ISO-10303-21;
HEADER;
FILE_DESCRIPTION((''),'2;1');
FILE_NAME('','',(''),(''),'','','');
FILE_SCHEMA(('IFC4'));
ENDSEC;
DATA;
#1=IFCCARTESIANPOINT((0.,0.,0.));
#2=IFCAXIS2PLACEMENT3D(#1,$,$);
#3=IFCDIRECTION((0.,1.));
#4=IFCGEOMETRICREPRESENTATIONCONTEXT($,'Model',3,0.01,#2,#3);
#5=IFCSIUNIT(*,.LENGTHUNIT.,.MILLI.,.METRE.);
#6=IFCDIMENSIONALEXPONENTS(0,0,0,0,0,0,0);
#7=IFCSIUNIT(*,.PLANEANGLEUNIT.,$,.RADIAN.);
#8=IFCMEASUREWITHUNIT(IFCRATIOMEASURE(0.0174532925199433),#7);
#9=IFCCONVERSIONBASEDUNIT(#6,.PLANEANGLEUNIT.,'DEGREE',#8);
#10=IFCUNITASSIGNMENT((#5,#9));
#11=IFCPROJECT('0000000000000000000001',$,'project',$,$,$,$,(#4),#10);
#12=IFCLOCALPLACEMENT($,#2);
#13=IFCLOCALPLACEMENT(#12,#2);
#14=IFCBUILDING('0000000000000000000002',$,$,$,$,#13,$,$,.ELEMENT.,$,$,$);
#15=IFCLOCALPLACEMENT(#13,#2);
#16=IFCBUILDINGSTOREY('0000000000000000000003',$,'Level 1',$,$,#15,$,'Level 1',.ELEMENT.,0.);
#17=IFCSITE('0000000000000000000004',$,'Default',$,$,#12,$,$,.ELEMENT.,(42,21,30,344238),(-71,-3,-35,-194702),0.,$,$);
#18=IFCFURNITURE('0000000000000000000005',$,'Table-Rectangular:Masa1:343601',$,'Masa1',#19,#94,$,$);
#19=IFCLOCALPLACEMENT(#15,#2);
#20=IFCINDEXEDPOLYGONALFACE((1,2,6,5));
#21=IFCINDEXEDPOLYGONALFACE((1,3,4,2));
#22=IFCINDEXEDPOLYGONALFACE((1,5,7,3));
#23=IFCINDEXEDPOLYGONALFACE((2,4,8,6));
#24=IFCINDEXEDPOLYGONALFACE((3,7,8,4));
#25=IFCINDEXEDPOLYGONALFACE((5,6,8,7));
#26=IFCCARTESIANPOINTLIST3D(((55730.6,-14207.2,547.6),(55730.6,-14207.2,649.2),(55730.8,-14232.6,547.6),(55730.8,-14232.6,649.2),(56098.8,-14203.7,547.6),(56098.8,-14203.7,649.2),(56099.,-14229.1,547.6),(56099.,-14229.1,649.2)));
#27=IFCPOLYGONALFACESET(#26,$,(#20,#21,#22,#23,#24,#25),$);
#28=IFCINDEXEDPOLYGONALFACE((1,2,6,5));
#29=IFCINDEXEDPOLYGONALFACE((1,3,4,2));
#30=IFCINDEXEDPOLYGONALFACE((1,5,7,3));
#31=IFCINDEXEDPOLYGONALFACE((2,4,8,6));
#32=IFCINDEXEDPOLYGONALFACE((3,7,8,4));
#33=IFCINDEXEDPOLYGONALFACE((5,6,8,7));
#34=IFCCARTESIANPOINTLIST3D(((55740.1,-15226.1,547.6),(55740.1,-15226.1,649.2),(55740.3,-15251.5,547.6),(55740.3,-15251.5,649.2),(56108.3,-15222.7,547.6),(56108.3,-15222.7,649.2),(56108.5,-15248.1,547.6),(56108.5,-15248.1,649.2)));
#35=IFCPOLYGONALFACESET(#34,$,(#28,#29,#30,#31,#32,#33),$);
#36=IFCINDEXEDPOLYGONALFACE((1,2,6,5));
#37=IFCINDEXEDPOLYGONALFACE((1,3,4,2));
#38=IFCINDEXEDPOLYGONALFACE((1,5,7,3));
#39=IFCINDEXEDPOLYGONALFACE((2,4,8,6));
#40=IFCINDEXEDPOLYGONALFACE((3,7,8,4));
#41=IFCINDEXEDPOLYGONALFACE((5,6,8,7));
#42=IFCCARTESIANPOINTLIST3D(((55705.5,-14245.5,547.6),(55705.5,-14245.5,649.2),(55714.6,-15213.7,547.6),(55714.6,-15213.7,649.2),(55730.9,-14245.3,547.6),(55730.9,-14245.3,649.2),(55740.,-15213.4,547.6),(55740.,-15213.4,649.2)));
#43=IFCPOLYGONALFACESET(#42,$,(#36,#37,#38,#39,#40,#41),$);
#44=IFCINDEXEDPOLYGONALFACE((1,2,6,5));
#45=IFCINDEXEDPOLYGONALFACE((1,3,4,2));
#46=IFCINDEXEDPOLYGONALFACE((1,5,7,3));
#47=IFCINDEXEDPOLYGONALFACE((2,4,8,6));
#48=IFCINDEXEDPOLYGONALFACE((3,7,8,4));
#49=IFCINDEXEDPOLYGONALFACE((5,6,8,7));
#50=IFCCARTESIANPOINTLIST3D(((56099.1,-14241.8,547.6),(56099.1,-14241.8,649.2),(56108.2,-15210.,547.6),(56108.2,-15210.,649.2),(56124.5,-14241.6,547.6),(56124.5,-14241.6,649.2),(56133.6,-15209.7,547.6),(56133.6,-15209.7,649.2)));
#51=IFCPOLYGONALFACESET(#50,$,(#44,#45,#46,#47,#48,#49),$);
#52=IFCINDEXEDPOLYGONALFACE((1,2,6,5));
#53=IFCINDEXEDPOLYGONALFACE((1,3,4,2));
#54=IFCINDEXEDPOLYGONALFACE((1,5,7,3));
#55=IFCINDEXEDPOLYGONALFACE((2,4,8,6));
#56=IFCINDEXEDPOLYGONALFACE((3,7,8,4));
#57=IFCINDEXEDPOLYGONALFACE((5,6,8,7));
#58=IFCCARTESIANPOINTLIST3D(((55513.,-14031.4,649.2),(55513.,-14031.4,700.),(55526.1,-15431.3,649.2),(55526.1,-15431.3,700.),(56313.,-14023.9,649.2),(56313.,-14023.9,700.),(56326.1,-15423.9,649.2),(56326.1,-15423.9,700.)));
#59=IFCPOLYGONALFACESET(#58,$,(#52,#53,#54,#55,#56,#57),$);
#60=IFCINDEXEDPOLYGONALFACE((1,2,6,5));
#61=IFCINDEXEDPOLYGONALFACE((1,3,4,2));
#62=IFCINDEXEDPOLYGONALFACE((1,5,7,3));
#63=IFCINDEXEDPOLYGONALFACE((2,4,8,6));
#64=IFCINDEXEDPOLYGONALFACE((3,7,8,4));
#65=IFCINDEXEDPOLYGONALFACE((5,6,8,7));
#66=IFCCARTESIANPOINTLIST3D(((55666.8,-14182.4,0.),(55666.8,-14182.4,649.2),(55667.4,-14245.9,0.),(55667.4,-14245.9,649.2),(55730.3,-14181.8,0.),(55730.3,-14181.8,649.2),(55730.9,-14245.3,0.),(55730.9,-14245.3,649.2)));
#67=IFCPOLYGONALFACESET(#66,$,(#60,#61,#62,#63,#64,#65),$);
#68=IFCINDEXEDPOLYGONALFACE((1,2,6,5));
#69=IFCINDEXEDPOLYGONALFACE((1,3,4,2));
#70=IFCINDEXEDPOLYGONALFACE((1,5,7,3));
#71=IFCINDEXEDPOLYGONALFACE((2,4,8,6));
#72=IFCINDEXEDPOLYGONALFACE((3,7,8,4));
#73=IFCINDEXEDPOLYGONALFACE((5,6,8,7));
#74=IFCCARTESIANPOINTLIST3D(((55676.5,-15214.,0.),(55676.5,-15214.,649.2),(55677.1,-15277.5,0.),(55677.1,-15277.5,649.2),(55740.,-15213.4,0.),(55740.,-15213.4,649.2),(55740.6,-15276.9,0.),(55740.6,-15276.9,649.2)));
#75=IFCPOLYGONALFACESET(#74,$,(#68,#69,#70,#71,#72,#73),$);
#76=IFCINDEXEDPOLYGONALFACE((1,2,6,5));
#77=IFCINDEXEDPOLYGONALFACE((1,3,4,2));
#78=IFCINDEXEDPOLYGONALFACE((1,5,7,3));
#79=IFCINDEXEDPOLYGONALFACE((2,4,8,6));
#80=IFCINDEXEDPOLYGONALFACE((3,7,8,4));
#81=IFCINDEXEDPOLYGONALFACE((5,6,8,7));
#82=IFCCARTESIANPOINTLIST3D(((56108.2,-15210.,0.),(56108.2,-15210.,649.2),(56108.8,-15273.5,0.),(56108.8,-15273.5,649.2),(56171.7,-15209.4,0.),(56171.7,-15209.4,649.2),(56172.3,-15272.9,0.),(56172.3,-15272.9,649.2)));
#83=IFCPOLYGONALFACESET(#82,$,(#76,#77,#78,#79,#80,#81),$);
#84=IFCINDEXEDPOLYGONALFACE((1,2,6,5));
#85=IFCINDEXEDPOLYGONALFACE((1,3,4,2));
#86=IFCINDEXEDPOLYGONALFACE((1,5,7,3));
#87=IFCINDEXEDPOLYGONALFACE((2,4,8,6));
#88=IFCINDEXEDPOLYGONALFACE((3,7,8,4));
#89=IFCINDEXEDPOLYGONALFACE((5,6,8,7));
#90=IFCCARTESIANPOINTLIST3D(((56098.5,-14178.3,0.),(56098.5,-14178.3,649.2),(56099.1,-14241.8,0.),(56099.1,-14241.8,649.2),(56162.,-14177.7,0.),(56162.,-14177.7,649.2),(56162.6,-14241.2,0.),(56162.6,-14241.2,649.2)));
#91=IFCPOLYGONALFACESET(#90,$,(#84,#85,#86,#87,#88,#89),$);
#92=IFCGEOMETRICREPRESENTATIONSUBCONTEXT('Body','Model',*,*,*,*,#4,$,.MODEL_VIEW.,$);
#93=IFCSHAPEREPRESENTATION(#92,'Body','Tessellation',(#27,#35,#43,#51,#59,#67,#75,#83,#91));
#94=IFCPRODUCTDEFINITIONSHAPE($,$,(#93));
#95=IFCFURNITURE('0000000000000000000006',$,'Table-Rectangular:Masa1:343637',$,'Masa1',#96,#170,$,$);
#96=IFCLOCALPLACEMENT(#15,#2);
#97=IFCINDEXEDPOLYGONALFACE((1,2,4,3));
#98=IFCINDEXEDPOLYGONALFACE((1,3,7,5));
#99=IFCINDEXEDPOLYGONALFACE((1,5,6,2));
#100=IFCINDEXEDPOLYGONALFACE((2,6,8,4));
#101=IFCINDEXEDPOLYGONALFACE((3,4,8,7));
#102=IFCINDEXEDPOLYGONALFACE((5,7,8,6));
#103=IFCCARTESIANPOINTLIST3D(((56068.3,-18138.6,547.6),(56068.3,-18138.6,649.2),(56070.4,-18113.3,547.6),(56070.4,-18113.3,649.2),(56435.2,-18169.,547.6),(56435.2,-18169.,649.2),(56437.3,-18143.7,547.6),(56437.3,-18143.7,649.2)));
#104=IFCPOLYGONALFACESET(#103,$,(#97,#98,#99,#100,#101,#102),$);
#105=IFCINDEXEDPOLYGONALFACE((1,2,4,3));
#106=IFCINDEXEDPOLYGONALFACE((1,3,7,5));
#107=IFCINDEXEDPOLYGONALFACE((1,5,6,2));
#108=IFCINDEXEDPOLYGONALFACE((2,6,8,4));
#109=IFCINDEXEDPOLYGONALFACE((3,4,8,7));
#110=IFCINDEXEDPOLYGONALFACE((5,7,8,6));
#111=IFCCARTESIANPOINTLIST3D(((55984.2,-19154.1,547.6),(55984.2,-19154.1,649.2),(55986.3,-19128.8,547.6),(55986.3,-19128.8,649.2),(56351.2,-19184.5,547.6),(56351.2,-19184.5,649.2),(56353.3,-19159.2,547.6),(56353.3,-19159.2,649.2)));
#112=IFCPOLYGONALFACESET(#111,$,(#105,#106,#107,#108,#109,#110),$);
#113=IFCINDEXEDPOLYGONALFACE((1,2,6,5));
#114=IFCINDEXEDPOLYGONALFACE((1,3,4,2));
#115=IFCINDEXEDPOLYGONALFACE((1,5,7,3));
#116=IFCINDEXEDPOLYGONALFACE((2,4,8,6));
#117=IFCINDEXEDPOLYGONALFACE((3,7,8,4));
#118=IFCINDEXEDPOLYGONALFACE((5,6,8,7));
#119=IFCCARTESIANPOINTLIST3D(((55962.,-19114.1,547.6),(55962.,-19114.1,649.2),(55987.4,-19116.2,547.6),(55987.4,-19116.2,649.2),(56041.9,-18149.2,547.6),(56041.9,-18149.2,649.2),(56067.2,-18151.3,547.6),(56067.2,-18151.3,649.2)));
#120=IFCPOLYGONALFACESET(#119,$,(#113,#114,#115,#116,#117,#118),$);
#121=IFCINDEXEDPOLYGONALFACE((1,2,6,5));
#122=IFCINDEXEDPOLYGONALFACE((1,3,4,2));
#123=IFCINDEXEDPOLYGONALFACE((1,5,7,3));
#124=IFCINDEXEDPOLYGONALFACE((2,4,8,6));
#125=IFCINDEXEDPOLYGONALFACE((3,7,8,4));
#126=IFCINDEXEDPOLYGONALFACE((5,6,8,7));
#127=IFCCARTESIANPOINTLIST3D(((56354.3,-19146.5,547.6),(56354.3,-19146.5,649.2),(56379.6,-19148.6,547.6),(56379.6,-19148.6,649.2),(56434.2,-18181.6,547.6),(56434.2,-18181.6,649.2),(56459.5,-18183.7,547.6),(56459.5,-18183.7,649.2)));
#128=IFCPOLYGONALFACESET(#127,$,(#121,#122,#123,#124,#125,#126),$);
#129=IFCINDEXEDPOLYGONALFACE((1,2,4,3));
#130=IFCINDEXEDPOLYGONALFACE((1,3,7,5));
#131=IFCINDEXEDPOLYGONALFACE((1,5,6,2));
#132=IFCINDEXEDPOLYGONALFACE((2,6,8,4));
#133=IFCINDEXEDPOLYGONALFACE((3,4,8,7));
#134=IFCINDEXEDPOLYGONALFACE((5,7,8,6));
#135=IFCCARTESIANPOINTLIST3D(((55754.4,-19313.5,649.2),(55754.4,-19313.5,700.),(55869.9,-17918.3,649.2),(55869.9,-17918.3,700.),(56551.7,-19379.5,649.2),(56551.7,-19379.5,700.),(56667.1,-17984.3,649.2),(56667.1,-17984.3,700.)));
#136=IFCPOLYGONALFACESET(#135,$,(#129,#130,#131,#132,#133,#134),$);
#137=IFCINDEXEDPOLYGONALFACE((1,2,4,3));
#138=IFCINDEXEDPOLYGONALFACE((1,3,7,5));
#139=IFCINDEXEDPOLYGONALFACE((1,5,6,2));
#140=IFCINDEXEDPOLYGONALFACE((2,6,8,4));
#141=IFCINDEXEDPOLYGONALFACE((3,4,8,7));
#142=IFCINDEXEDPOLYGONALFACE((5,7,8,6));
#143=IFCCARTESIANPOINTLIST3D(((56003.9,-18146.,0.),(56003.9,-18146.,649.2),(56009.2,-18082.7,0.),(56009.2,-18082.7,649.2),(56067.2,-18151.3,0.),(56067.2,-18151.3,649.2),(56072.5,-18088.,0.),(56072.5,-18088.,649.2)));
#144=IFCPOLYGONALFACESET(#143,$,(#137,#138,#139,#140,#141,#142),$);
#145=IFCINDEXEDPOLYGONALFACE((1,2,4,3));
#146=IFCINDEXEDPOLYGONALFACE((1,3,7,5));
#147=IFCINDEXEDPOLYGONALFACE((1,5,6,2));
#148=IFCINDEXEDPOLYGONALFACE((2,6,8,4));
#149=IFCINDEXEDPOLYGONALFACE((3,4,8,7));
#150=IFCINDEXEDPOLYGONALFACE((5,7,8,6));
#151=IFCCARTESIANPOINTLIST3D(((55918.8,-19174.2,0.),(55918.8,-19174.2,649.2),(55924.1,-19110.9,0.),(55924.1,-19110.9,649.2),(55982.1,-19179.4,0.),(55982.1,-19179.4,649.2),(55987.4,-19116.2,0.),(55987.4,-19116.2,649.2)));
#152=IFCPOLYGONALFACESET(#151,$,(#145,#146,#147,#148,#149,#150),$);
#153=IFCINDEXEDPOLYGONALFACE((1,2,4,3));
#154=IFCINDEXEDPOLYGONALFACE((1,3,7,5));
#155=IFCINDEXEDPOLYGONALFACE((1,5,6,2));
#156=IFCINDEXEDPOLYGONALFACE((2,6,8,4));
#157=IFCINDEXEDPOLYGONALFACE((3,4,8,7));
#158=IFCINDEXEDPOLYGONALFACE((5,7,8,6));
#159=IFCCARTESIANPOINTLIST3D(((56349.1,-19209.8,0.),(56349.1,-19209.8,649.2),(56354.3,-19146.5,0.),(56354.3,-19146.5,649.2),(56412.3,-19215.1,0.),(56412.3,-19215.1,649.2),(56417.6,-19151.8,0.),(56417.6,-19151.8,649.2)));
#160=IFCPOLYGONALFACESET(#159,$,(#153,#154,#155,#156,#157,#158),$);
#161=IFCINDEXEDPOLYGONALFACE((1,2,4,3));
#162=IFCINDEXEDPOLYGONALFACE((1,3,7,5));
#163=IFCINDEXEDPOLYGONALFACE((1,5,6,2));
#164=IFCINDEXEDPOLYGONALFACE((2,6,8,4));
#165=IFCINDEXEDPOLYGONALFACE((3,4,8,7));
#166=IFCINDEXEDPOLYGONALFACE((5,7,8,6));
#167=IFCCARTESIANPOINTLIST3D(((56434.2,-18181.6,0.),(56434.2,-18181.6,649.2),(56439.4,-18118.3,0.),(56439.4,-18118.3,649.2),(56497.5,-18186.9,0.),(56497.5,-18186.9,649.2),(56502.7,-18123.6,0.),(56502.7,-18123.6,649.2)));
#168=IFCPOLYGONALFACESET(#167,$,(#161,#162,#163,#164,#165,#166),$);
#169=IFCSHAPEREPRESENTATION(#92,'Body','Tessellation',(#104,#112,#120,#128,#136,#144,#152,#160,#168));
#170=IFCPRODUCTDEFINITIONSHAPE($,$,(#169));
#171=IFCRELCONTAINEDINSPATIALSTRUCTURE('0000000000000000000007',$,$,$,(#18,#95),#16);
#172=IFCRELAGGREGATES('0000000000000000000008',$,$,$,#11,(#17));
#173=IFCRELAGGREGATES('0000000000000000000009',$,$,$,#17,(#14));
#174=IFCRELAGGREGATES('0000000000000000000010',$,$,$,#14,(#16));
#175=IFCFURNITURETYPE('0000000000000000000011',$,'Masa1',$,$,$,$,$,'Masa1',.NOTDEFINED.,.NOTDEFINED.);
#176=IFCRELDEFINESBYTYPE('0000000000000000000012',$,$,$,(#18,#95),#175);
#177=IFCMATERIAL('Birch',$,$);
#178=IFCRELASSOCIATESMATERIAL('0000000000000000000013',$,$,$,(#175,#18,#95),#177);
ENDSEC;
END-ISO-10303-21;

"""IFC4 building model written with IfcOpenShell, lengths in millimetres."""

from ifc_helpers import new_model, entity, si_unit, converted_unit, direction, frame, frame_2d, origin, origin_2d_with_axis, place, context, subcontext, project, spatial, rectangle, extrude, source, transform, mapped, material, type_object, type_shapes, element, save


model = new_model("IFC4")

# Units and contexts
model_context = context("Model", 3, precision=0.01, world=origin(), true_north=direction((0.0, 1.0)))
body_context = subcontext(model_context, "Body", "Model", "MODEL_VIEW")
ifc_project = project(units=[si_unit("LENGTHUNIT", "METRE", prefix="MILLI"), converted_unit("PLANEANGLEUNIT", "DEGREE", entity("IfcRatioMeasure", 0.0174532925199433), si_unit("PLANEANGLEUNIT", "RADIAN"), dimensions=[0, 0, 0, 0, 0, 0, 0])], contexts=[model_context])

# Site, building, storey
site_placement = place(None, origin())
site = spatial("IfcSite", under=ifc_project, at=site_placement, Name="Default", CompositionType="ELEMENT", RefLatitude=(42, 21, 30, 344238), RefLongitude=(-71, -3, -35, -194702), RefElevation=0.0)
building_placement = place(site_placement, origin())
building = spatial("IfcBuilding", under=site, at=building_placement, CompositionType="ELEMENT")
storey_placement = place(building_placement, origin())
storey = spatial("IfcBuildingStorey", under=building, at=storey_placement, Name="Level 1", LongName="Level 1", CompositionType="ELEMENT", Elevation=0.0)

# Furniture
ifc_material_1 = material(Name="Birch")
furniture_type_1 = type_object("IfcFurnitureType", Name="Masa1", ElementType="Masa1", AssemblyPlace="NOTDEFINED", PredefinedType="NOTDEFINED", material=ifc_material_1)
shared_shape_1 = source(origin(), body_context, "Body", "SweptSolid", [
    extrude(rectangle(XDim=25.4, YDim=368.2, at=origin_2d_with_axis()), frame((509.5, 0.0, 547.6)), (0.0, 0.0, 1.0), 101.6),
    extrude(rectangle(XDim=368.2, YDim=25.4, at=origin_2d_with_axis()), frame((-509.5, 0.0, 547.6), z_axis=(0.0, 0.0, 1.0), x_axis=(0.0, 1.0, 0.0)), (0.0, 0.0, 1.0), 101.6),
    extrude(rectangle(XDim=968.2, YDim=25.4, at=frame_2d((0.0, 0.0), x_axis=(1.0, 0.0))), frame((0.0, 196.8, 547.6), z_axis=(0.0, 0.0, 1.0), x_axis=(-1.0, 0.0, 0.0)), (0.0, 0.0, 1.0), 101.6),
    extrude(rectangle(XDim=25.4, YDim=968.2, at=origin_2d_with_axis()), frame((0.0, -196.8, 547.6), z_axis=(0.0, 0.0, 1.0), x_axis=(0.0, 1.0, 0.0)), (0.0, 0.0, 1.0), 101.6),
    extrude(rectangle(XDim=1400.0, YDim=800.0, at=origin_2d_with_axis()), frame((0.0, 0.0, 649.2), z_axis=(0.0, 0.0, 1.0), x_axis=(-1.0, 0.0, 0.0)), (0.0, 0.0, 1.0), 50.8),
    extrude(rectangle(XDim=63.5, YDim=63.5, at=origin_2d_with_axis()), frame((515.9, 215.9, 0.0), z_axis=(0.0, 0.0, 1.0), x_axis=(0.0, -1.0, 0.0)), (0.0, 0.0, 1.0), 649.2),
    extrude(rectangle(XDim=63.5, YDim=63.5, at=origin_2d_with_axis()), frame((-515.9, 215.9, 0.0), z_axis=(0.0, 0.0, 1.0), x_axis=(-1.0, 0.0, 0.0)), (0.0, 0.0, 1.0), 649.2),
    extrude(rectangle(XDim=63.5, YDim=63.5, at=origin_2d_with_axis()), frame((-515.9, -215.9, 0.0), z_axis=(0.0, 0.0, 1.0), x_axis=(0.0, 1.0, 0.0)), (0.0, 0.0, 1.0), 649.2),
    extrude(rectangle(XDim=63.5, YDim=63.5, at=frame_2d((0.0, 0.0), x_axis=(1.0, 0.0))), frame((515.9, -215.9, 0.0)), (0.0, 0.0, 1.0), 649.2),
])
type_shapes(furniture_type_1, [shared_shape_1])
for number, where, z_axis, x_axis, name in (
    (1, (55919.6, -14727.6, 0.0), (0.0, 0.0, 1.0), (-0.009355, 0.999956, 0.0), "Table-Rectangular:Masa1:343601"),
    (2, (56210.8, -18648.9, 0.0), (0.0, 0.0, 1.0), (0.082491, 0.996592, 0.0), "Table-Rectangular:Masa1:343637"),
):
    element("IfcFurniture", number, at=place(storey_placement, frame(where, z_axis=z_axis, x_axis=x_axis)), inside=storey, type_object=furniture_type_1, material=ifc_material_1, Name=name, ObjectType="Masa1", context=body_context, shape_type="MappedRepresentation", body=[
        mapped(shared_shape_1, transform((0.0, 0.0, 0.0), scale=1.0)),
    ])

save(model, "model.ifc")
